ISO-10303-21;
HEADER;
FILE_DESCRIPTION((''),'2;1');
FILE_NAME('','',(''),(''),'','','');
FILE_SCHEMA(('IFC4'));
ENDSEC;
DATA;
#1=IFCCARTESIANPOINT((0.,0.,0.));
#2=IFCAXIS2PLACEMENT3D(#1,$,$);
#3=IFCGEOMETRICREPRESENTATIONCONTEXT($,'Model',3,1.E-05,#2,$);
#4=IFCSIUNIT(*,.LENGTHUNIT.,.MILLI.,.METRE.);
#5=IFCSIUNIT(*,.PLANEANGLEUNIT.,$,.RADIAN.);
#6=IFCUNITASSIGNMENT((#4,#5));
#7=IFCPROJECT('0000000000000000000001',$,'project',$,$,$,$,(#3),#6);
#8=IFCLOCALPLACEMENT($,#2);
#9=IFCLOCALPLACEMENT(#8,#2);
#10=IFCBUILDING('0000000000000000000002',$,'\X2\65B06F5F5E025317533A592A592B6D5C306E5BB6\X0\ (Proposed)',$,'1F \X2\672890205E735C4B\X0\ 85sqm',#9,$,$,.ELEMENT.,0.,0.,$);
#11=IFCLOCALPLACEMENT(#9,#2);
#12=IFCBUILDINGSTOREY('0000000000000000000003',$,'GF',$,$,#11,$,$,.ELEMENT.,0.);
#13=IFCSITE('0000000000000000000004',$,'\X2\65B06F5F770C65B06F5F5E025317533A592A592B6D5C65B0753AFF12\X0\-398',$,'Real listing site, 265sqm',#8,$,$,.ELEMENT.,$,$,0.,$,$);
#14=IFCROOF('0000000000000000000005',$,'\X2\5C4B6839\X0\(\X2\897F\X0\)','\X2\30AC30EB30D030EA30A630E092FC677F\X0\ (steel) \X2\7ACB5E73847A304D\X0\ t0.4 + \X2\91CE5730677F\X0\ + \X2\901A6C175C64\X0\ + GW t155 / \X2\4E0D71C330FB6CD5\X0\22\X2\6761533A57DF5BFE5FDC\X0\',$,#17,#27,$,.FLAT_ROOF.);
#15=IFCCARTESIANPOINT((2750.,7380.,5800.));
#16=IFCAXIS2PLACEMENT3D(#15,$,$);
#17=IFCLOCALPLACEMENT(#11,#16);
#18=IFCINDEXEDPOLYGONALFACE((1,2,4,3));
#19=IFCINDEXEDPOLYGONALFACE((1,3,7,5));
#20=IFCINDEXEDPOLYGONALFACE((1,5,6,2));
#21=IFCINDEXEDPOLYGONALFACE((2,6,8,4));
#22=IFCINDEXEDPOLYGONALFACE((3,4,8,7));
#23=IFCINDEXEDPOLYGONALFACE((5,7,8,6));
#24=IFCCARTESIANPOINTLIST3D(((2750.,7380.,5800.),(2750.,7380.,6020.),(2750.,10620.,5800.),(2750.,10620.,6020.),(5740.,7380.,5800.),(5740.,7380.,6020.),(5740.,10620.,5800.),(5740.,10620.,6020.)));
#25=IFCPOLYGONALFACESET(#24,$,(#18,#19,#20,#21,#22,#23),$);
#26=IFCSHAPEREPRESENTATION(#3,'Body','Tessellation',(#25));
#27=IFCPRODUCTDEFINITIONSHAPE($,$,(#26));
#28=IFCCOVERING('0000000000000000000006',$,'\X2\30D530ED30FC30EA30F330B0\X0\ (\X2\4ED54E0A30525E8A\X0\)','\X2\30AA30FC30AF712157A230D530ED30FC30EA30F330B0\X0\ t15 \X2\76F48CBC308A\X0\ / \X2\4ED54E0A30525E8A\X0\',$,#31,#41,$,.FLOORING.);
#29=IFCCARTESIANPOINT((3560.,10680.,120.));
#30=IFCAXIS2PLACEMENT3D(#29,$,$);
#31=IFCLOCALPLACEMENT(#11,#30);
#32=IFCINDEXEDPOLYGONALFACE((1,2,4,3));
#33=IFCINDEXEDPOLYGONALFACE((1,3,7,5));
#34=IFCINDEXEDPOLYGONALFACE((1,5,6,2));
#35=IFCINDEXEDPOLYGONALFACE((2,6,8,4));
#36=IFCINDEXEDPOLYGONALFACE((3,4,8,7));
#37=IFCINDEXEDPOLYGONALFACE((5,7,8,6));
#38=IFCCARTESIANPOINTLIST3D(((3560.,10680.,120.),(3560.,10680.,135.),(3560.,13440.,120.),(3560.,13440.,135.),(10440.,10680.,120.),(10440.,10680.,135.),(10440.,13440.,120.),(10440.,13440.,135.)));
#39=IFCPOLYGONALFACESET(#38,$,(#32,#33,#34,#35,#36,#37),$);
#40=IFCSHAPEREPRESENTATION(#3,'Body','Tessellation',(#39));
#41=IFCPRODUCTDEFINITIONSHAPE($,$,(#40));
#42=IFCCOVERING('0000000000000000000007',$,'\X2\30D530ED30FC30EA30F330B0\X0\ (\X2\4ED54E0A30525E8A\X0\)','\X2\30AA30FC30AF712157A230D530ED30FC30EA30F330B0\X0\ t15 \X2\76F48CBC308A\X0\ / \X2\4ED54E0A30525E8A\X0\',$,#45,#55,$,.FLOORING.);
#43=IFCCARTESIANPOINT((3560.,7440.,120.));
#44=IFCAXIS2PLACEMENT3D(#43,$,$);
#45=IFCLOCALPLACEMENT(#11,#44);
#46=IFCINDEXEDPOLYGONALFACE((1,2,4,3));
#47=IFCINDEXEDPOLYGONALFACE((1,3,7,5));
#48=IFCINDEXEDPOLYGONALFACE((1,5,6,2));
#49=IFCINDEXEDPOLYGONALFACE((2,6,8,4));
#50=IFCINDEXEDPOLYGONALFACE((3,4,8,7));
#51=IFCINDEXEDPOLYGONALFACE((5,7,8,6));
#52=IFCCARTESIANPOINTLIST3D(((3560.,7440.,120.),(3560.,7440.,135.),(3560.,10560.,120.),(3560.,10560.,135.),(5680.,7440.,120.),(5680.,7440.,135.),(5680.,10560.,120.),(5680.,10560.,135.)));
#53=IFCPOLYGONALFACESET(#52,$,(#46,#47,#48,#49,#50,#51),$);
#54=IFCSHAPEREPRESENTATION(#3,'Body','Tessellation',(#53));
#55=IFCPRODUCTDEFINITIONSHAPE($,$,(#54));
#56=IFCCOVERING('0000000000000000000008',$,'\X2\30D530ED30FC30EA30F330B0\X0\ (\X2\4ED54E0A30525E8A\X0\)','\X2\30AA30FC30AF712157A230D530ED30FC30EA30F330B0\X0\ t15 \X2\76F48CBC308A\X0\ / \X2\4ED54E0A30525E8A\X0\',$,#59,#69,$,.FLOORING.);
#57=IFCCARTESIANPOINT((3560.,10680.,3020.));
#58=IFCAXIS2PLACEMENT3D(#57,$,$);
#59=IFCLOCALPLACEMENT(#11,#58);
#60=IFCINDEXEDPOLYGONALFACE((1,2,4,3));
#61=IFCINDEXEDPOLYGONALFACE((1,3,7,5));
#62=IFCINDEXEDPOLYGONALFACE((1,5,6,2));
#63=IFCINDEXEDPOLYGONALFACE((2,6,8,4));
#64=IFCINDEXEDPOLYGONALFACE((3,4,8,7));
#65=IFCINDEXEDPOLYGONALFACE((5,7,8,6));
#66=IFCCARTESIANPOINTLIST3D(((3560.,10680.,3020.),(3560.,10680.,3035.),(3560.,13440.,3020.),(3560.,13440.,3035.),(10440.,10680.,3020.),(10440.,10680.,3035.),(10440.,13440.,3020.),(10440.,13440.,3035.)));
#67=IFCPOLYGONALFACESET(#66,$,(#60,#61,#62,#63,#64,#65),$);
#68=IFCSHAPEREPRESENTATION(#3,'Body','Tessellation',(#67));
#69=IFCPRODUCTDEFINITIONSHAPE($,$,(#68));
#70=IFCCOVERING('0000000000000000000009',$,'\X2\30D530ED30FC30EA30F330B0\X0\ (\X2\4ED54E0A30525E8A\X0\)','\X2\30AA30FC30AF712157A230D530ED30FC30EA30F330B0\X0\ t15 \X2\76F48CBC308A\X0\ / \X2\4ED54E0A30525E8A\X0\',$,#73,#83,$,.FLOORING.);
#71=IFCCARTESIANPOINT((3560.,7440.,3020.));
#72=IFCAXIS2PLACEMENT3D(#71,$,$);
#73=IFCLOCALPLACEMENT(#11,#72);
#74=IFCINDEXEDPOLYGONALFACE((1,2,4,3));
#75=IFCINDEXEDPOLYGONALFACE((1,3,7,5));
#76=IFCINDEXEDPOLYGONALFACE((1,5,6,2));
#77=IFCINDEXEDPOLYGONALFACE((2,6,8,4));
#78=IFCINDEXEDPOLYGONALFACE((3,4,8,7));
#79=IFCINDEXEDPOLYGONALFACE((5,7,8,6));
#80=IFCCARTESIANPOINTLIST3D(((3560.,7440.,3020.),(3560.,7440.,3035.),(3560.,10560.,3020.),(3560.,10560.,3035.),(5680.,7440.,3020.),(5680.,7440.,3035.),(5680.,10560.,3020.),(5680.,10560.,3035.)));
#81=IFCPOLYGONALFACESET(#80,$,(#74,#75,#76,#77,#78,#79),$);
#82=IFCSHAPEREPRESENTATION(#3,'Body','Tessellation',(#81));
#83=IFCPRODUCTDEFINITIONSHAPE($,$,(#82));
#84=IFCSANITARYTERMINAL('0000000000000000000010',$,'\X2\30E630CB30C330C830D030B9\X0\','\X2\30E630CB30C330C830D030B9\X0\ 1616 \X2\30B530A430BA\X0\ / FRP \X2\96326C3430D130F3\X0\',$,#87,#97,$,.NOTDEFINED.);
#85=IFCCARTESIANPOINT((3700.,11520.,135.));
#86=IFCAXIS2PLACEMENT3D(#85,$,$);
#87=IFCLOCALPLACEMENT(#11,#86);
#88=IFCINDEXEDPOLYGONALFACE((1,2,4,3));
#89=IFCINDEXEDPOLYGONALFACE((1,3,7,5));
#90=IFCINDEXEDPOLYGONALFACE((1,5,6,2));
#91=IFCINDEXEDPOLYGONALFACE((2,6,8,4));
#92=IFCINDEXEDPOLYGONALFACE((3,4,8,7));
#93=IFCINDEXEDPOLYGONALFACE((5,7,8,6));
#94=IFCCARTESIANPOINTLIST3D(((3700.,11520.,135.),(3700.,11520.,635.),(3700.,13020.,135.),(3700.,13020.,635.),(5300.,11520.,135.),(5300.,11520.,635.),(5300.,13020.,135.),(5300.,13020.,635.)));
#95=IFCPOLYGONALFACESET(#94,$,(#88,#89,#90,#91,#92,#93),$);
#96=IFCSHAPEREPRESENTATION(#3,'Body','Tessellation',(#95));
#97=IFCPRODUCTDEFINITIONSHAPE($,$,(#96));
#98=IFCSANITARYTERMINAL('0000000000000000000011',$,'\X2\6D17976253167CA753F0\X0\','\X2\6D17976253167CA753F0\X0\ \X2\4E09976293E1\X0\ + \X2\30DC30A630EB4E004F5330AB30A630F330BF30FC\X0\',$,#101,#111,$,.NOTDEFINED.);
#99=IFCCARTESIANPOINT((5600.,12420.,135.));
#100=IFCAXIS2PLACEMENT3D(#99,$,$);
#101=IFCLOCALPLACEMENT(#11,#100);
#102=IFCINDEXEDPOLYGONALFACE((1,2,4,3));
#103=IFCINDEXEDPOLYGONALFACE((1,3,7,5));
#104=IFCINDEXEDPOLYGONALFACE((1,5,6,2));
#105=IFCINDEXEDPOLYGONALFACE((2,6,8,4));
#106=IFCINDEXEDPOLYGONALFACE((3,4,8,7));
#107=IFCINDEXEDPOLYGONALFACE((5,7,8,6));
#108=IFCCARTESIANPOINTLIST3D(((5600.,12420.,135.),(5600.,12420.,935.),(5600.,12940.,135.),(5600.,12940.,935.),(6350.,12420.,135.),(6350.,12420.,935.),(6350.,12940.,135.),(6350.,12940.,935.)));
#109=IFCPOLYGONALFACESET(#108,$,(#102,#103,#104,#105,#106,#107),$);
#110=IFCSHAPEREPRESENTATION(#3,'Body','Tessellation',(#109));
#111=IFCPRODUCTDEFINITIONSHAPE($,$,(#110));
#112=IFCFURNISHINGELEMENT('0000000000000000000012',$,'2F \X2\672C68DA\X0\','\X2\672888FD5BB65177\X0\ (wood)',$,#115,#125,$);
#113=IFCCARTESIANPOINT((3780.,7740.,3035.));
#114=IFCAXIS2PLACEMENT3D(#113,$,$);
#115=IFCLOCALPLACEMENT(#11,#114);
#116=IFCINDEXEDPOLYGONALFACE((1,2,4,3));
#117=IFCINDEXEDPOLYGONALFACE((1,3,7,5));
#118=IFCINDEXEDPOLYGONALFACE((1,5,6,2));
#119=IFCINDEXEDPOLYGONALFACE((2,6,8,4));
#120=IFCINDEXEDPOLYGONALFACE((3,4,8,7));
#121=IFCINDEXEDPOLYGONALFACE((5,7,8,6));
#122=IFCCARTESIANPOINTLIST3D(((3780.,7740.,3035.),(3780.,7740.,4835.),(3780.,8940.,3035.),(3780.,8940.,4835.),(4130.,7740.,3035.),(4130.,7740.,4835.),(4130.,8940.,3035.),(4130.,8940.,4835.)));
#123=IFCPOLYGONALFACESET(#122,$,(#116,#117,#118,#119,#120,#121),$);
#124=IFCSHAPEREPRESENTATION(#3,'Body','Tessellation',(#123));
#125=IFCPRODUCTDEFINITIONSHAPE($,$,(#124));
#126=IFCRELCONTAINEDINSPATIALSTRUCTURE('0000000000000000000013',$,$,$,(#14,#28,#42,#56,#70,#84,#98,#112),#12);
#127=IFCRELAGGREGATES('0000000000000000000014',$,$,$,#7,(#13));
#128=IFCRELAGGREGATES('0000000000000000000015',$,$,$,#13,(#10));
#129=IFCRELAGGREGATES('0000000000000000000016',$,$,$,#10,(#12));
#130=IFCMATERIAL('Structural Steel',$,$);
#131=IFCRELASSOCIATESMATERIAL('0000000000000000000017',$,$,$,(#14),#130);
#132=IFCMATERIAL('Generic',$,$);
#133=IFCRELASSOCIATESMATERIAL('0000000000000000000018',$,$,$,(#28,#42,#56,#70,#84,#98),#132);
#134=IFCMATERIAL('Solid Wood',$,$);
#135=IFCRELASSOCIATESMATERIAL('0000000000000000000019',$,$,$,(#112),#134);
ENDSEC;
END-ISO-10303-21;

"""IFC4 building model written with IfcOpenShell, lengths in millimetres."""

from ifc_helpers import new_model, si_unit, frame, frame_2d, origin, place, context, project, spatial, rectangle, extrude, material, element, save


model = new_model("IFC4")

# Units and contexts
model_context = context("Model", 3, precision=1e-05, world=origin())
ifc_project = project(units=[si_unit("LENGTHUNIT", "METRE", prefix="MILLI"), si_unit("PLANEANGLEUNIT", "RADIAN")], contexts=[model_context])

# Site, building, storey
site_placement = place(None, origin())
site = spatial("IfcSite", under=ifc_project, at=site_placement, Name="新潟県新潟市北区太夫浜新町２-398", ObjectType="Real listing site, 265sqm", CompositionType="ELEMENT", RefElevation=0.0)
building_placement = place(site_placement, origin())
building = spatial("IfcBuilding", under=site, at=building_placement, Name="新潟市北区太夫浜の家 (Proposed)", ObjectType="1F 木造平屋 85sqm", CompositionType="ELEMENT", ElevationOfRefHeight=0.0, ElevationOfTerrain=0.0)
storey_placement = place(building_placement, origin())
storey = spatial("IfcBuildingStorey", under=building, at=storey_placement, Name="GF", CompositionType="ELEMENT", Elevation=0.0)

# Shared definitions
ifc_material_1 = material(Name="Solid Wood")

# Roof
ifc_material_2 = material(Name="Structural Steel")
roof_placement = place(storey_placement, frame((2750.0, 7380.0, 5800.0)))
element("IfcRoof", 1, at=roof_placement, inside=storey, material=ifc_material_2, Name="屋根(西)", Description="ガルバリウム鋼板 (steel) 立平葺き t0.4 + 野地板 + 通気層 + GW t155 / 不燃・法22条区域対応", PredefinedType="FLAT_ROOF", context=model_context, shape_type="SweptSolid", body=[
    extrude(rectangle(XDim=2990.0, YDim=3240.0, at=frame_2d((1495.0, 1620.0))), frame((2750.0, 7380.0, 5800.0)), (0.0, 0.0, 1.0), 220.0),
])

# Coverings
ifc_material_3 = material(Name="Generic")
covering_1_placement = place(storey_placement, frame((3560.0, 10680.0, 120.0)))
element("IfcCovering", 2, at=covering_1_placement, inside=storey, material=ifc_material_3, Name="フローリング (仕上げ床)", Description="オーク無垢フローリング t15 直貼り / 仕上げ床", PredefinedType="FLOORING", context=model_context, shape_type="SweptSolid", body=[
    extrude(rectangle(XDim=6880.0, YDim=2760.0, at=frame_2d((3440.0, 1380.0))), frame((3560.0, 10680.0, 120.0)), (0.0, 0.0, 1.0), 15.0),
])
covering_2_placement = place(storey_placement, frame((3560.0, 7440.0, 120.0)))
element("IfcCovering", 3, at=covering_2_placement, inside=storey, material=ifc_material_3, Name="フローリング (仕上げ床)", Description="オーク無垢フローリング t15 直貼り / 仕上げ床", PredefinedType="FLOORING", context=model_context, shape_type="SweptSolid", body=[
    extrude(rectangle(XDim=2120.0, YDim=3120.0, at=frame_2d((1060.0, 1560.0))), frame((3560.0, 7440.0, 120.0)), (0.0, 0.0, 1.0), 15.0),
])
covering_3_placement = place(storey_placement, frame((3560.0, 10680.0, 3020.0)))
element("IfcCovering", 4, at=covering_3_placement, inside=storey, material=ifc_material_3, Name="フローリング (仕上げ床)", Description="オーク無垢フローリング t15 直貼り / 仕上げ床", PredefinedType="FLOORING", context=model_context, shape_type="SweptSolid", body=[
    extrude(rectangle(XDim=6880.0, YDim=2760.0, at=frame_2d((3440.0, 1380.0))), frame((3560.0, 10680.0, 3020.0)), (0.0, 0.0, 1.0), 15.0),
])
covering_4_placement = place(storey_placement, frame((3560.0, 7440.0, 3020.0)))
element("IfcCovering", 5, at=covering_4_placement, inside=storey, material=ifc_material_3, Name="フローリング (仕上げ床)", Description="オーク無垢フローリング t15 直貼り / 仕上げ床", PredefinedType="FLOORING", context=model_context, shape_type="SweptSolid", body=[
    extrude(rectangle(XDim=2120.0, YDim=3120.0, at=frame_2d((1060.0, 1560.0))), frame((3560.0, 7440.0, 3020.0)), (0.0, 0.0, 1.0), 15.0),
])

# Sanitary terminals
sanitary_terminal_1_placement = place(storey_placement, frame((3700.0, 11520.0, 135.0)))
element("IfcSanitaryTerminal", 6, at=sanitary_terminal_1_placement, inside=storey, material=ifc_material_3, Name="ユニットバス", Description="ユニットバス 1616 サイズ / FRP 防水パン", PredefinedType="NOTDEFINED", context=model_context, shape_type="SweptSolid", body=[
    extrude(rectangle(XDim=1600.0, YDim=1500.0, at=frame_2d((800.0, 750.0))), frame((3700.0, 11520.0, 135.0)), (0.0, 0.0, 1.0), 500.0),
])
sanitary_terminal_2_placement = place(storey_placement, frame((5600.0, 12420.0, 135.0)))
element("IfcSanitaryTerminal", 7, at=sanitary_terminal_2_placement, inside=storey, material=ifc_material_3, Name="洗面化粧台", Description="洗面化粧台 三面鏡 + ボウル一体カウンター", PredefinedType="NOTDEFINED", context=model_context, shape_type="SweptSolid", body=[
    extrude(rectangle(XDim=750.0, YDim=520.0, at=frame_2d((375.0, 260.0))), frame((5600.0, 12420.0, 135.0)), (0.0, 0.0, 1.0), 800.0),
])

# Furnishing element
furnishing_placement = place(storey_placement, frame((3780.0, 7740.0, 3035.0)))
element("IfcFurnishingElement", 8, at=furnishing_placement, inside=storey, material=ifc_material_1, Name="2F 本棚", Description="木製家具 (wood)", context=model_context, shape_type="SweptSolid", body=[
    extrude(rectangle(XDim=350.0, YDim=1200.0, at=frame_2d((175.0, 600.0))), frame((3780.0, 7740.0, 3035.0)), (0.0, 0.0, 1.0), 1800.0),
])

save(model, "model.ifc")
